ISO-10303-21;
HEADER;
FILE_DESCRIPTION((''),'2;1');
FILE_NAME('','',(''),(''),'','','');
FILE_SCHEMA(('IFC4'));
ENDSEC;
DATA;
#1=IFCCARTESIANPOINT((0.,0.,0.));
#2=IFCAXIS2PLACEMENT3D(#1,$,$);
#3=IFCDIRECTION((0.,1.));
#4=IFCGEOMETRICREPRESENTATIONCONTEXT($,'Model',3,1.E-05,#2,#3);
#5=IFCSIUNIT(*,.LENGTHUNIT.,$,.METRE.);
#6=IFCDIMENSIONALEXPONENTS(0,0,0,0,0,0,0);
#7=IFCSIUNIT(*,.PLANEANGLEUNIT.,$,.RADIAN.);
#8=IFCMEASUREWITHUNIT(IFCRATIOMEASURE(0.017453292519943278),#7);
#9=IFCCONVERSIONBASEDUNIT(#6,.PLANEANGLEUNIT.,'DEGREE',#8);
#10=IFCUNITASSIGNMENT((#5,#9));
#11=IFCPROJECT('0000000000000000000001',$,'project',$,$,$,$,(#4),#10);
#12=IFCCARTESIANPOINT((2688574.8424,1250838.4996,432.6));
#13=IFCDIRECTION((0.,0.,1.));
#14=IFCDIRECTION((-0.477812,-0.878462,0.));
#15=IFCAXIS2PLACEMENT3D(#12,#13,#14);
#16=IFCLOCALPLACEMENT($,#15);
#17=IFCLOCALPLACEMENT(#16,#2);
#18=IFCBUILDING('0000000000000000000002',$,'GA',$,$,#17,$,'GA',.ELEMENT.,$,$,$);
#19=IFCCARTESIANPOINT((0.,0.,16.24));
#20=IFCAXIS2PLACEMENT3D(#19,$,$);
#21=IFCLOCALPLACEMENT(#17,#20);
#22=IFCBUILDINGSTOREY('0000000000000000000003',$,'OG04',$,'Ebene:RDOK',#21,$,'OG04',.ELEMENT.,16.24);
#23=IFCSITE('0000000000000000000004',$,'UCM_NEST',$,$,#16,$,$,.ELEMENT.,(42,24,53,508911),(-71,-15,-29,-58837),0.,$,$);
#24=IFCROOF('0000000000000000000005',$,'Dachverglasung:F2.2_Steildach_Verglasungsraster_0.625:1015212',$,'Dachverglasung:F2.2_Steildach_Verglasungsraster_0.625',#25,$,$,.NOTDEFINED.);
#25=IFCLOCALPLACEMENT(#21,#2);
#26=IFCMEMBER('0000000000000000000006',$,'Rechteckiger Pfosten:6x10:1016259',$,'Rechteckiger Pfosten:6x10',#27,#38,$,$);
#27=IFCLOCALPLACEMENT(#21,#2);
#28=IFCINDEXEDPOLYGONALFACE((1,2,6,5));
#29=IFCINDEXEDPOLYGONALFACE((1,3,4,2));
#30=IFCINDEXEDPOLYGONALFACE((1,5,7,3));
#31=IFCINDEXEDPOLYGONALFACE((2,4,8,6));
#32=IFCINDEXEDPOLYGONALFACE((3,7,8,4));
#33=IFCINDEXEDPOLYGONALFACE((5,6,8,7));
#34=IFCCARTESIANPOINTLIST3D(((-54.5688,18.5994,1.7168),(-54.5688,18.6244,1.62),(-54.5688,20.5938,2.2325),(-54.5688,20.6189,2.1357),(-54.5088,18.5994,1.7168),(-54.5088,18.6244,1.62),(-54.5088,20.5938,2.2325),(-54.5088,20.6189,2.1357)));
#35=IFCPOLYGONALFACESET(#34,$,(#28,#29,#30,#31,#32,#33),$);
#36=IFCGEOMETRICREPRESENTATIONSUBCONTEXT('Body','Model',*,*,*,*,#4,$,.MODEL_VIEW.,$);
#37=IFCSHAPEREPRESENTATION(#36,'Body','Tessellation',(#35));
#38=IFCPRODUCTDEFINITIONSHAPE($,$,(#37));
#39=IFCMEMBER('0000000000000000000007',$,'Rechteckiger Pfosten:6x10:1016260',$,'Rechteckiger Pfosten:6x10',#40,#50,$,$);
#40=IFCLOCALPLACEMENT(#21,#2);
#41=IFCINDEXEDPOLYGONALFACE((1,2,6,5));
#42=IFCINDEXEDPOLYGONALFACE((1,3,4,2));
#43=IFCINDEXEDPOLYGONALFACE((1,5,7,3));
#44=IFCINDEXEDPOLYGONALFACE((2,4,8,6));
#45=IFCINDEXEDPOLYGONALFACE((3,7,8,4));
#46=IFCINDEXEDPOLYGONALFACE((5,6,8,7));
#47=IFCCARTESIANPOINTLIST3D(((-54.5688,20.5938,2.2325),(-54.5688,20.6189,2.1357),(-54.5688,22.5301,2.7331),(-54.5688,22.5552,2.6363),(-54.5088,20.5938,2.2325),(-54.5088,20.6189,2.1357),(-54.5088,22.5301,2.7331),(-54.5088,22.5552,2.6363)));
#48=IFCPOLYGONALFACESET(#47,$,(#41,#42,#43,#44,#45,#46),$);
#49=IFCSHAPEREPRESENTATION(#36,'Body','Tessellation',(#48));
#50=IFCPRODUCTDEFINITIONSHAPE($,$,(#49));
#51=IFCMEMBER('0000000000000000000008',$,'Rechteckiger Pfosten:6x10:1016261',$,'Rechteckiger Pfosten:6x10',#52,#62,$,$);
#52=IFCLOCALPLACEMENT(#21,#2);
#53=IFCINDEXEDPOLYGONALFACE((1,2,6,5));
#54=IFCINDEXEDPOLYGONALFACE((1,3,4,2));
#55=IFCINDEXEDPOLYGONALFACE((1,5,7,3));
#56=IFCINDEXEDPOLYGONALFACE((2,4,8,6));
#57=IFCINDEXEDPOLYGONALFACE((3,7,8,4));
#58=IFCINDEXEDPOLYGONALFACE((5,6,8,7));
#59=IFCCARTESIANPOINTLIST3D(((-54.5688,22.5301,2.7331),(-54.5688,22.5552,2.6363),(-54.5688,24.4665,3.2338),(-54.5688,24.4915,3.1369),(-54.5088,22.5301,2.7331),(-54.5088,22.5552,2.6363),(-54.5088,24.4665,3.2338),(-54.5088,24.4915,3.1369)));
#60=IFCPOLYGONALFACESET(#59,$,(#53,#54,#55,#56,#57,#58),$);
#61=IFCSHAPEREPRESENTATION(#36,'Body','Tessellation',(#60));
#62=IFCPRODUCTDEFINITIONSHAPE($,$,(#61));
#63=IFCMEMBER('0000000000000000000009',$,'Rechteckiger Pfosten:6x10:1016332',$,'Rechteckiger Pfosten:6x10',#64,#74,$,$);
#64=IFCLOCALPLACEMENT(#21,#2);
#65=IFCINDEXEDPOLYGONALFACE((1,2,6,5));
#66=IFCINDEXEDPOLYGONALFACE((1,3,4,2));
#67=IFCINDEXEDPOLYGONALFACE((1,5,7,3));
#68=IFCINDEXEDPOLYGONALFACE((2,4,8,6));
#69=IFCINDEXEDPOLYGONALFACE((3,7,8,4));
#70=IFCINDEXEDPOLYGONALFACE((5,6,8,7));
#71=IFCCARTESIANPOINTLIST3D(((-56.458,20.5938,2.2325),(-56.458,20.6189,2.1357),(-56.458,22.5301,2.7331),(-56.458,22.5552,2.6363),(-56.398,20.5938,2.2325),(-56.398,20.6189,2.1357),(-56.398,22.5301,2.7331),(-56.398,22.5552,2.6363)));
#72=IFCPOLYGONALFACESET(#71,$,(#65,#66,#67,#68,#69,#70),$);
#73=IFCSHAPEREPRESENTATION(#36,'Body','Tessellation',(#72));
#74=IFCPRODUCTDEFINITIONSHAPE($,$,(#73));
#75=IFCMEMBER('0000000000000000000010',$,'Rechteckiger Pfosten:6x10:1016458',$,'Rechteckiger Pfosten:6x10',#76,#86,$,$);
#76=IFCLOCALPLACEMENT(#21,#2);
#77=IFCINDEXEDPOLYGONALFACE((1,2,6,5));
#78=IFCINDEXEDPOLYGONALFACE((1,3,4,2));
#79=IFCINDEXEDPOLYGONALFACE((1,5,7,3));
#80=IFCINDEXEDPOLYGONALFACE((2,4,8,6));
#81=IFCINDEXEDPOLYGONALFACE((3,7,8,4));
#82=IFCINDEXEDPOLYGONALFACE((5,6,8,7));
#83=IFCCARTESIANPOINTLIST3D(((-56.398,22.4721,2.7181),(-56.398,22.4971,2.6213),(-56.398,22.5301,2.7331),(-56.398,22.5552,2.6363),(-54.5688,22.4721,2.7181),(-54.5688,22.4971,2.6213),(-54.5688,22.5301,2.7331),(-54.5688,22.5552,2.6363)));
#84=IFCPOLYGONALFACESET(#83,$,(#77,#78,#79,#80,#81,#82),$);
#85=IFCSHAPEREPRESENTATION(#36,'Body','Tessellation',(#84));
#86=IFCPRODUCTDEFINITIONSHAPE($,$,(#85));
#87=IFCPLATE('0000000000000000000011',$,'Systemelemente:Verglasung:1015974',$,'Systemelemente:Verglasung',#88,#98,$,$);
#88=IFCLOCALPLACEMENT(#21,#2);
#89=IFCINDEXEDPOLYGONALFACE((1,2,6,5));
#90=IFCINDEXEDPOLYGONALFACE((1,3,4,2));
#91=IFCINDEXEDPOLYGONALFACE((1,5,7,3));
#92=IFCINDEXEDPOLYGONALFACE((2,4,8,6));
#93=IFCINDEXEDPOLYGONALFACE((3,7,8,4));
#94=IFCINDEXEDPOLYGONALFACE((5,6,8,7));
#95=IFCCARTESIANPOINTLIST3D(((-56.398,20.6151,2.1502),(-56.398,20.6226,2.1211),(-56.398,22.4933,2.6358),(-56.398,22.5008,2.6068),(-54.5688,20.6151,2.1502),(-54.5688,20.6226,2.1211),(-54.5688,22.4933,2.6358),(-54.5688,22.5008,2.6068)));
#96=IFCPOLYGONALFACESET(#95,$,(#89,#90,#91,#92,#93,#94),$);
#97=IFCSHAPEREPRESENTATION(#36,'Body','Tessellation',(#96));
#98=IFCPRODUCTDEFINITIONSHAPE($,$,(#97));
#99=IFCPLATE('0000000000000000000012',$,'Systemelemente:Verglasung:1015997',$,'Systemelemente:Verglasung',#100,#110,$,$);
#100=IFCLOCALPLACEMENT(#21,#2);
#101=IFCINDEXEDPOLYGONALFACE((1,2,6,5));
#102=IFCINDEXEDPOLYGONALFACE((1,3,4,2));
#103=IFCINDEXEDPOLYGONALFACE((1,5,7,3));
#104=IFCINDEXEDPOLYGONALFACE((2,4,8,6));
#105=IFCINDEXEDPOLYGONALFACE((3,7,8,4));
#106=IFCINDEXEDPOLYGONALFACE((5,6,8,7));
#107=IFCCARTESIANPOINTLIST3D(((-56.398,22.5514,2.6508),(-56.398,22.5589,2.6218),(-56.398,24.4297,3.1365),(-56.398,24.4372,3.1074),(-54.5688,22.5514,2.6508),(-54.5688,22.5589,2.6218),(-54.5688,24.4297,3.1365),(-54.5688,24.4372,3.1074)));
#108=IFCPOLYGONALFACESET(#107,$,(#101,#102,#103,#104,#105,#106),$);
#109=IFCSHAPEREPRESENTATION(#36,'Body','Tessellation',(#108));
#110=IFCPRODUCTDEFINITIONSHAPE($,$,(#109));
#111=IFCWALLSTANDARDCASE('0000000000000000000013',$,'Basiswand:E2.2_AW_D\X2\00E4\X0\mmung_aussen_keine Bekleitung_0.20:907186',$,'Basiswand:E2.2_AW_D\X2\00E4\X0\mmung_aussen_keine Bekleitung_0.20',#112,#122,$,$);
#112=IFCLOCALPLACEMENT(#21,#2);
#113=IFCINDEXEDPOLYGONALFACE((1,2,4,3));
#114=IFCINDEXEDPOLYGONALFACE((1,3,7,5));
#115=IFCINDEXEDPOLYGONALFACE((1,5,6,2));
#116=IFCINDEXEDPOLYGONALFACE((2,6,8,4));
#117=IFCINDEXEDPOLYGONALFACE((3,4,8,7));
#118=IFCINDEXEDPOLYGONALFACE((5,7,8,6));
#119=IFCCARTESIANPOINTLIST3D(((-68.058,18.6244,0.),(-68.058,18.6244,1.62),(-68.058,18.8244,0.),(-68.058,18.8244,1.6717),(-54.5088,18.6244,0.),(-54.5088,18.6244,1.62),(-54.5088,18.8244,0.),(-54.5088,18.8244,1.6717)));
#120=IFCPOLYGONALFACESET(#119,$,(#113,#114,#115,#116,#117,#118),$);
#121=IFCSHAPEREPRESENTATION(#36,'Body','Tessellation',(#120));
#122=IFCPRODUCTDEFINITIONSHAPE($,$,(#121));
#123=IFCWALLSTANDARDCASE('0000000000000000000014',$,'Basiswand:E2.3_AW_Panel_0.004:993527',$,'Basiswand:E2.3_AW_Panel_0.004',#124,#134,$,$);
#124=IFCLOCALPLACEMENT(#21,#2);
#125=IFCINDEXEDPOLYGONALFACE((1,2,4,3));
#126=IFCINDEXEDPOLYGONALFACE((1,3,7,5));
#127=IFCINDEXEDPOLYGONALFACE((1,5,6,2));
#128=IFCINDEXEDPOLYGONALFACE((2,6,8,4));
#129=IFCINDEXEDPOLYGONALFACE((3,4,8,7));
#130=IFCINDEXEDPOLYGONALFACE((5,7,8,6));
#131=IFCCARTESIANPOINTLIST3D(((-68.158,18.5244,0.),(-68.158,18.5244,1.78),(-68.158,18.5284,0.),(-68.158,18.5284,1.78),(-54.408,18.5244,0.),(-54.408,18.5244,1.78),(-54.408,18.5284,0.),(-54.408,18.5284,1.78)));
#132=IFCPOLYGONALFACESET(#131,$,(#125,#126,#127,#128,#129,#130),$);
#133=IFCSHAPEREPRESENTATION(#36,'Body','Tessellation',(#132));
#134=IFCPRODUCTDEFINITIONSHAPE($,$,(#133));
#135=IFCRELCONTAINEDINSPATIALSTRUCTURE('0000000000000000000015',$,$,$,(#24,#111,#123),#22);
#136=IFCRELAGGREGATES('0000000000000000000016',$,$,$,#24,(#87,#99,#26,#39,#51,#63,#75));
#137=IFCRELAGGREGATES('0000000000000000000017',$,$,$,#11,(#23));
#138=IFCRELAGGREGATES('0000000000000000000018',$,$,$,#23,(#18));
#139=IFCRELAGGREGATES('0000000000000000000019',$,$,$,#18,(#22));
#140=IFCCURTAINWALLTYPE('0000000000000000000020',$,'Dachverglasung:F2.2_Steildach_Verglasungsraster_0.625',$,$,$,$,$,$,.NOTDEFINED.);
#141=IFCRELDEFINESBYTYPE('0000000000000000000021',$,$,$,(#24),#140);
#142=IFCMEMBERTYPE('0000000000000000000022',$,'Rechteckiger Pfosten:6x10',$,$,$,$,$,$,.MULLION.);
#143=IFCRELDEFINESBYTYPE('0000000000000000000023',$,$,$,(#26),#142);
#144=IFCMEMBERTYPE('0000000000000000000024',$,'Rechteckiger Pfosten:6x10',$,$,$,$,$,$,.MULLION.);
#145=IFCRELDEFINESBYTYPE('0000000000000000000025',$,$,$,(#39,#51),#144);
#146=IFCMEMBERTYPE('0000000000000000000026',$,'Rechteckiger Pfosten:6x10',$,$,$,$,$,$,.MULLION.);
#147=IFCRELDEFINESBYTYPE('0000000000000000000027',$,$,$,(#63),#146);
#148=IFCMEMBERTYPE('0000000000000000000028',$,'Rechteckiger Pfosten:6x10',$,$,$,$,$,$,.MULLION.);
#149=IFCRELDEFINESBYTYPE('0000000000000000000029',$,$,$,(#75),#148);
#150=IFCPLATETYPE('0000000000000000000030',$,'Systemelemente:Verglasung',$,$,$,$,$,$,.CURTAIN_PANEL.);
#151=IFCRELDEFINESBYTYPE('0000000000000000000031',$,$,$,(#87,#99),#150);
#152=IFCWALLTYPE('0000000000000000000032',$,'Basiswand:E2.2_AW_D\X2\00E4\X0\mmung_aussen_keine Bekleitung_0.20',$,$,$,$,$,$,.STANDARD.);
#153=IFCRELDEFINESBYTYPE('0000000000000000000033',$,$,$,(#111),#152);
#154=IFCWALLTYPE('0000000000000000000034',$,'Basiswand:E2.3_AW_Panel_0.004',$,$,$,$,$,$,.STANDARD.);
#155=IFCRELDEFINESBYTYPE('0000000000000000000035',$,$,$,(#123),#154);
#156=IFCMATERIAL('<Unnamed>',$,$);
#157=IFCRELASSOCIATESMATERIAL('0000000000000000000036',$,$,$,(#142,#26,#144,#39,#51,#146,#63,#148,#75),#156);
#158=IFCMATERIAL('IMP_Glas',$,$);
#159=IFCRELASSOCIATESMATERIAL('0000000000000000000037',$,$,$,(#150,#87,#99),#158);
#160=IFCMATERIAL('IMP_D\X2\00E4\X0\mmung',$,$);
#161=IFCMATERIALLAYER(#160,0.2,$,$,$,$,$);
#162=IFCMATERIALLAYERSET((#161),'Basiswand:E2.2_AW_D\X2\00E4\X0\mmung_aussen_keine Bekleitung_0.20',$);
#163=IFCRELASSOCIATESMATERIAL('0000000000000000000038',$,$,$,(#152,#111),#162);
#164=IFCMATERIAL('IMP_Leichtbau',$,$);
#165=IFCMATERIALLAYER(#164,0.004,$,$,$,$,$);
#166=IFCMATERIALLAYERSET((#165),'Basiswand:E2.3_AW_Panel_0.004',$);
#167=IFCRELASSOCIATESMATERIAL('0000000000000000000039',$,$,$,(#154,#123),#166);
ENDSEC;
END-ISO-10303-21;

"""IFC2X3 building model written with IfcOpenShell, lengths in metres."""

from ifc_helpers import new_model, entity, si_unit, converted_unit, direction, frame, frame_2d, origin, origin_2d_with_axis, place, context, subcontext, project, spatial, polyline, rectangle, extrude, clip, bounded_halfspace, source, transform, mapped, material, layer, layer_set, layer_usage, type_object, type_shapes, element, aggregate, save


model = new_model("IFC2X3")

# Units and contexts
model_context = context("Model", 3, precision=1e-05, world=origin(), true_north=direction((0.0, 1.0)))
body_context = subcontext(model_context, "Body", "Model", "MODEL_VIEW")
ifc_project = project(units=[si_unit("LENGTHUNIT", "METRE"), converted_unit("PLANEANGLEUNIT", "DEGREE", entity("IfcRatioMeasure", 0.017453292519943278), si_unit("PLANEANGLEUNIT", "RADIAN"), dimensions=[0, 0, 0, 0, 0, 0, 0])], contexts=[model_context])

# Site, building, storey
site_placement = place(None, frame((2688574.8424, 1250838.4996, 432.6), z_axis=(0.0, 0.0, 1.0), x_axis=(-0.477812, -0.878462, 0.0)))
site = spatial("IfcSite", under=ifc_project, at=site_placement, Name="UCM_NEST", CompositionType="ELEMENT", RefLatitude=(42, 24, 53, 508911), RefLongitude=(-71, -15, -29, -58837), RefElevation=0.0)
building_placement = place(site_placement, origin())
building = spatial("IfcBuilding", under=site, at=building_placement, Name="GA", LongName="GA", CompositionType="ELEMENT")
storey_placement = place(building_placement, frame((0.0, 0.0, 16.24)))
storey = spatial("IfcBuildingStorey", under=building, at=storey_placement, Name="OG04", ObjectType="Ebene:RDOK", LongName="OG04", CompositionType="ELEMENT", Elevation=16.24)

# Roof, members, plates
curtain_wall_type = type_object("IfcCurtainWallType", Name="Dachverglasung:F2.2_Steildach_Verglasungsraster_0.625", PredefinedType="NOTDEFINED")
roof_placement = place(storey_placement, frame((0.0, 0.0, -16.24)))
roof = element("IfcRoof", 1, at=roof_placement, inside=storey, type_object=curtain_wall_type, Name="Dachverglasung:F2.2_Steildach_Verglasungsraster_0.625:1015212", ObjectType="Dachverglasung:F2.2_Steildach_Verglasungsraster_0.625", ShapeType="NOTDEFINED")
ifc_material_1 = material(Name="<Unnamed>")
member_type_1 = type_object("IfcMemberType", Name="Rechteckiger Pfosten:6x10", PredefinedType="MULLION", material=ifc_material_1)
shared_shape_1 = source(origin(), body_context, "Body", "SweptSolid", [
    extrude(rectangle(XDim=0.1, YDim=0.06, at=frame_2d((0.0, 0.0), x_axis=(1.0, 0.0))), frame((-0.03, -0.05, -2.06), z_axis=(0.0, 0.0, 1.0), x_axis=(0.0, -1.0, 0.0)), (0.0, 0.0, 1.0), 2.06),
])
type_shapes(member_type_1, [shared_shape_1])
member_1_placement = place(roof_placement, frame((-54.5088, 20.6189, 18.3757), z_axis=(0.0, 0.968163, 0.250322), x_axis=(1.0, 0.0, 0.0)))
member_1 = element("IfcMember", 2, at=member_1_placement, type_object=member_type_1, material=ifc_material_1, Name="Rechteckiger Pfosten:6x10:1016259", ObjectType="Rechteckiger Pfosten:6x10", context=body_context, shape_type="MappedRepresentation", body=[
    mapped(shared_shape_1, transform((0.0, 0.0, 0.0), scale=1.0)),
])
member_type_2 = type_object("IfcMemberType", Name="Rechteckiger Pfosten:6x10", PredefinedType="MULLION", material=ifc_material_1)
shared_shape_2 = source(origin(), body_context, "Body", "SweptSolid", [
    extrude(rectangle(XDim=0.1, YDim=0.06, at=origin_2d_with_axis()), frame((-0.03, -0.05, -2.0), z_axis=(0.0, 0.0, 1.0), x_axis=(0.0, -1.0, 0.0)), (0.0, 0.0, 1.0), 2.0),
])
type_shapes(member_type_2, [shared_shape_2])
member_2_placement = place(roof_placement, frame((-54.5088, 22.5552, 18.8763), z_axis=(0.0, 0.968163, 0.250322), x_axis=(1.0, 0.0, 0.0)))
member_2 = element("IfcMember", 3, at=member_2_placement, type_object=member_type_2, material=ifc_material_1, Name="Rechteckiger Pfosten:6x10:1016260", ObjectType="Rechteckiger Pfosten:6x10", context=body_context, shape_type="MappedRepresentation", body=[
    mapped(shared_shape_2, transform((0.0, 0.0, 0.0), scale=1.0)),
])
member_3_placement = place(roof_placement, frame((-54.5088, 24.4915, 19.3769), z_axis=(0.0, 0.968163, 0.250322), x_axis=(1.0, 0.0, 0.0)))
member_3 = element("IfcMember", 4, at=member_3_placement, type_object=member_type_2, material=ifc_material_1, Name="Rechteckiger Pfosten:6x10:1016261", ObjectType="Rechteckiger Pfosten:6x10", context=body_context, shape_type="MappedRepresentation", body=[
    mapped(shared_shape_2, transform((0.0, 0.0, 0.0), scale=1.0)),
])
member_type_3 = type_object("IfcMemberType", Name="Rechteckiger Pfosten:6x10", PredefinedType="MULLION", material=ifc_material_1)
shared_shape_3 = source(origin(), body_context, "Body", "SweptSolid", [
    extrude(rectangle(XDim=0.1, YDim=0.06, at=origin_2d_with_axis()), frame((-0.03, -0.05, -2.0), z_axis=(0.0, 0.0, 1.0), x_axis=(0.0, -1.0, 0.0)), (0.0, 0.0, 1.0), 2.0),
])
type_shapes(member_type_3, [shared_shape_3])
member_4_placement = place(roof_placement, frame((-56.398, 22.5552, 18.8763), z_axis=(0.0, 0.968163, 0.250322), x_axis=(1.0, 0.0, 0.0)))
member_4 = element("IfcMember", 5, at=member_4_placement, type_object=member_type_3, material=ifc_material_1, Name="Rechteckiger Pfosten:6x10:1016332", ObjectType="Rechteckiger Pfosten:6x10", context=body_context, shape_type="MappedRepresentation", body=[
    mapped(shared_shape_3, transform((0.0, 0.0, 0.0), scale=1.0)),
])
member_type_4 = type_object("IfcMemberType", Name="Rechteckiger Pfosten:6x10", PredefinedType="MULLION", material=ifc_material_1)
shared_shape_4 = source(origin(), body_context, "Body", "SweptSolid", [
    extrude(rectangle(XDim=0.1, YDim=0.06, at=origin_2d_with_axis()), frame((-0.03, -0.05, -1.8292), z_axis=(0.0, 0.0, 1.0), x_axis=(0.0, -1.0, 0.0)), (0.0, 0.0, 1.0), 1.8292),
])
type_shapes(member_type_4, [shared_shape_4])
member_5_placement = place(roof_placement, frame((-56.398, 22.5552, 18.8763), z_axis=(-1.0, 0.0, 0.0), x_axis=(0.0, 0.968163, 0.250322)))
member_5 = element("IfcMember", 6, at=member_5_placement, type_object=member_type_4, material=ifc_material_1, Name="Rechteckiger Pfosten:6x10:1016458", ObjectType="Rechteckiger Pfosten:6x10", context=body_context, shape_type="MappedRepresentation", body=[
    mapped(shared_shape_4, transform((0.0, 0.0, 0.0), scale=1.0)),
])
ifc_material_2 = material(Name="IMP_Glas")
plate_type = type_object("IfcPlateType", Name="Systemelemente:Verglasung", PredefinedType="CURTAIN_PANEL", material=ifc_material_2)
shared_shape_5 = source(origin(), body_context, "Body", "SweptSolid", [
    extrude(rectangle(XDim=0.03, YDim=1.8292, at=origin_2d_with_axis()), frame((0.0, 0.0, 0.0), z_axis=(0.0, 0.0, 1.0), x_axis=(0.0, 1.0, 0.0)), (0.0, 0.0, 1.0), 1.94),
])
type_shapes(plate_type, [shared_shape_5])
plate_1_placement = place(roof_placement, frame((-55.4834, 20.6189, 18.3757), z_axis=(0.0, 0.968163, 0.250322), x_axis=(1.0, 0.0, 0.0)))
plate_1 = element("IfcPlate", 7, at=plate_1_placement, type_object=plate_type, material=ifc_material_2, Name="Systemelemente:Verglasung:1015974", ObjectType="Systemelemente:Verglasung", context=body_context, shape_type="MappedRepresentation", body=[
    mapped(shared_shape_5, transform((0.0, 0.0, 0.0), scale=1.0)),
])
plate_2_placement = place(roof_placement, frame((-55.4834, 22.5552, 18.8763), z_axis=(0.0, 0.968163, 0.250322), x_axis=(1.0, 0.0, 0.0)))
plate_2 = element("IfcPlate", 8, at=plate_2_placement, type_object=plate_type, material=ifc_material_2, Name="Systemelemente:Verglasung:1015997", ObjectType="Systemelemente:Verglasung", context=body_context, shape_type="MappedRepresentation", body=[
    mapped(shared_shape_5, transform((0.0, 0.0, 0.0), scale=1.0)),
])
aggregate(roof, [plate_1, plate_2, member_1, member_2, member_3, member_4, member_5])

# Walls
ifc_material_3 = material(Name="IMP_Dämmung")
ifc_layer_1 = layer(ifc_material_3, 0.2)
ifc_layer_set_1 = layer_set([ifc_layer_1], Name="Basiswand:E2.2_AW_Dämmung_aussen_keine Bekleitung_0.20")
ifc_layer_usage_1 = layer_usage(ifc_layer_set_1, "AXIS2", "NEGATIVE", 0.1)
wall_type_1 = type_object("IfcWallType", Name="Basiswand:E2.2_AW_Dämmung_aussen_keine Bekleitung_0.20", PredefinedType="STANDARD", material=ifc_layer_set_1)
wall_1_placement = place(storey_placement, frame((-54.5088, 18.7244, 0.0), z_axis=(0.0, 0.0, 1.0), x_axis=(-1.0, 0.0, 0.0)))
element("IfcWallStandardCase", 9, at=wall_1_placement, inside=storey, type_object=wall_type_1, material=ifc_layer_usage_1, Name="Basiswand:E2.2_AW_Dämmung_aussen_keine Bekleitung_0.20:907186", ObjectType="Basiswand:E2.2_AW_Dämmung_aussen_keine Bekleitung_0.20", context=body_context, shape_type="Clipping", body=[
    clip(extrude(rectangle(XDim=13.5492, YDim=0.2, at=frame_2d((6.7746, 0.0), x_axis=(-1.0, 0.0))), origin(), (0.0, 0.0, 1.0), 1.6717), bounded_halfspace(frame((0.0, -0.1, 1.6717), z_axis=(0.0, 0.250322, 0.968163), x_axis=(-1.0, 0.0, 0.0)), False, frame((0.0, -0.1, 1.6717)), polyline([(0.0, 0.0), (13.5492, 0.0), (13.5492, 0.2), (0.0, 0.2), (0.0, 0.0)]))),
])
ifc_material_4 = material(Name="IMP_Leichtbau")
ifc_layer_2 = layer(ifc_material_4, 0.004)
ifc_layer_set_2 = layer_set([ifc_layer_2], Name="Basiswand:E2.3_AW_Panel_0.004")
ifc_layer_usage_2 = layer_usage(ifc_layer_set_2, "AXIS2", "NEGATIVE", 0.002)
wall_type_2 = type_object("IfcWallType", Name="Basiswand:E2.3_AW_Panel_0.004", PredefinedType="STANDARD", material=ifc_layer_set_2)
wall_2_placement = place(storey_placement, frame((-54.408, 18.5264, 0.0), z_axis=(0.0, 0.0, 1.0), x_axis=(-1.0, 0.0, 0.0)))
element("IfcWallStandardCase", 10, at=wall_2_placement, inside=storey, type_object=wall_type_2, material=ifc_layer_usage_2, Name="Basiswand:E2.3_AW_Panel_0.004:993527", ObjectType="Basiswand:E2.3_AW_Panel_0.004", context=body_context, shape_type="SweptSolid", body=[
    extrude(rectangle(XDim=13.75, YDim=0.004, at=frame_2d((6.875, 0.0), x_axis=(-1.0, 0.0))), origin(), (0.0, 0.0, 1.0), 1.78),
])

save(model, "model.ifc")
